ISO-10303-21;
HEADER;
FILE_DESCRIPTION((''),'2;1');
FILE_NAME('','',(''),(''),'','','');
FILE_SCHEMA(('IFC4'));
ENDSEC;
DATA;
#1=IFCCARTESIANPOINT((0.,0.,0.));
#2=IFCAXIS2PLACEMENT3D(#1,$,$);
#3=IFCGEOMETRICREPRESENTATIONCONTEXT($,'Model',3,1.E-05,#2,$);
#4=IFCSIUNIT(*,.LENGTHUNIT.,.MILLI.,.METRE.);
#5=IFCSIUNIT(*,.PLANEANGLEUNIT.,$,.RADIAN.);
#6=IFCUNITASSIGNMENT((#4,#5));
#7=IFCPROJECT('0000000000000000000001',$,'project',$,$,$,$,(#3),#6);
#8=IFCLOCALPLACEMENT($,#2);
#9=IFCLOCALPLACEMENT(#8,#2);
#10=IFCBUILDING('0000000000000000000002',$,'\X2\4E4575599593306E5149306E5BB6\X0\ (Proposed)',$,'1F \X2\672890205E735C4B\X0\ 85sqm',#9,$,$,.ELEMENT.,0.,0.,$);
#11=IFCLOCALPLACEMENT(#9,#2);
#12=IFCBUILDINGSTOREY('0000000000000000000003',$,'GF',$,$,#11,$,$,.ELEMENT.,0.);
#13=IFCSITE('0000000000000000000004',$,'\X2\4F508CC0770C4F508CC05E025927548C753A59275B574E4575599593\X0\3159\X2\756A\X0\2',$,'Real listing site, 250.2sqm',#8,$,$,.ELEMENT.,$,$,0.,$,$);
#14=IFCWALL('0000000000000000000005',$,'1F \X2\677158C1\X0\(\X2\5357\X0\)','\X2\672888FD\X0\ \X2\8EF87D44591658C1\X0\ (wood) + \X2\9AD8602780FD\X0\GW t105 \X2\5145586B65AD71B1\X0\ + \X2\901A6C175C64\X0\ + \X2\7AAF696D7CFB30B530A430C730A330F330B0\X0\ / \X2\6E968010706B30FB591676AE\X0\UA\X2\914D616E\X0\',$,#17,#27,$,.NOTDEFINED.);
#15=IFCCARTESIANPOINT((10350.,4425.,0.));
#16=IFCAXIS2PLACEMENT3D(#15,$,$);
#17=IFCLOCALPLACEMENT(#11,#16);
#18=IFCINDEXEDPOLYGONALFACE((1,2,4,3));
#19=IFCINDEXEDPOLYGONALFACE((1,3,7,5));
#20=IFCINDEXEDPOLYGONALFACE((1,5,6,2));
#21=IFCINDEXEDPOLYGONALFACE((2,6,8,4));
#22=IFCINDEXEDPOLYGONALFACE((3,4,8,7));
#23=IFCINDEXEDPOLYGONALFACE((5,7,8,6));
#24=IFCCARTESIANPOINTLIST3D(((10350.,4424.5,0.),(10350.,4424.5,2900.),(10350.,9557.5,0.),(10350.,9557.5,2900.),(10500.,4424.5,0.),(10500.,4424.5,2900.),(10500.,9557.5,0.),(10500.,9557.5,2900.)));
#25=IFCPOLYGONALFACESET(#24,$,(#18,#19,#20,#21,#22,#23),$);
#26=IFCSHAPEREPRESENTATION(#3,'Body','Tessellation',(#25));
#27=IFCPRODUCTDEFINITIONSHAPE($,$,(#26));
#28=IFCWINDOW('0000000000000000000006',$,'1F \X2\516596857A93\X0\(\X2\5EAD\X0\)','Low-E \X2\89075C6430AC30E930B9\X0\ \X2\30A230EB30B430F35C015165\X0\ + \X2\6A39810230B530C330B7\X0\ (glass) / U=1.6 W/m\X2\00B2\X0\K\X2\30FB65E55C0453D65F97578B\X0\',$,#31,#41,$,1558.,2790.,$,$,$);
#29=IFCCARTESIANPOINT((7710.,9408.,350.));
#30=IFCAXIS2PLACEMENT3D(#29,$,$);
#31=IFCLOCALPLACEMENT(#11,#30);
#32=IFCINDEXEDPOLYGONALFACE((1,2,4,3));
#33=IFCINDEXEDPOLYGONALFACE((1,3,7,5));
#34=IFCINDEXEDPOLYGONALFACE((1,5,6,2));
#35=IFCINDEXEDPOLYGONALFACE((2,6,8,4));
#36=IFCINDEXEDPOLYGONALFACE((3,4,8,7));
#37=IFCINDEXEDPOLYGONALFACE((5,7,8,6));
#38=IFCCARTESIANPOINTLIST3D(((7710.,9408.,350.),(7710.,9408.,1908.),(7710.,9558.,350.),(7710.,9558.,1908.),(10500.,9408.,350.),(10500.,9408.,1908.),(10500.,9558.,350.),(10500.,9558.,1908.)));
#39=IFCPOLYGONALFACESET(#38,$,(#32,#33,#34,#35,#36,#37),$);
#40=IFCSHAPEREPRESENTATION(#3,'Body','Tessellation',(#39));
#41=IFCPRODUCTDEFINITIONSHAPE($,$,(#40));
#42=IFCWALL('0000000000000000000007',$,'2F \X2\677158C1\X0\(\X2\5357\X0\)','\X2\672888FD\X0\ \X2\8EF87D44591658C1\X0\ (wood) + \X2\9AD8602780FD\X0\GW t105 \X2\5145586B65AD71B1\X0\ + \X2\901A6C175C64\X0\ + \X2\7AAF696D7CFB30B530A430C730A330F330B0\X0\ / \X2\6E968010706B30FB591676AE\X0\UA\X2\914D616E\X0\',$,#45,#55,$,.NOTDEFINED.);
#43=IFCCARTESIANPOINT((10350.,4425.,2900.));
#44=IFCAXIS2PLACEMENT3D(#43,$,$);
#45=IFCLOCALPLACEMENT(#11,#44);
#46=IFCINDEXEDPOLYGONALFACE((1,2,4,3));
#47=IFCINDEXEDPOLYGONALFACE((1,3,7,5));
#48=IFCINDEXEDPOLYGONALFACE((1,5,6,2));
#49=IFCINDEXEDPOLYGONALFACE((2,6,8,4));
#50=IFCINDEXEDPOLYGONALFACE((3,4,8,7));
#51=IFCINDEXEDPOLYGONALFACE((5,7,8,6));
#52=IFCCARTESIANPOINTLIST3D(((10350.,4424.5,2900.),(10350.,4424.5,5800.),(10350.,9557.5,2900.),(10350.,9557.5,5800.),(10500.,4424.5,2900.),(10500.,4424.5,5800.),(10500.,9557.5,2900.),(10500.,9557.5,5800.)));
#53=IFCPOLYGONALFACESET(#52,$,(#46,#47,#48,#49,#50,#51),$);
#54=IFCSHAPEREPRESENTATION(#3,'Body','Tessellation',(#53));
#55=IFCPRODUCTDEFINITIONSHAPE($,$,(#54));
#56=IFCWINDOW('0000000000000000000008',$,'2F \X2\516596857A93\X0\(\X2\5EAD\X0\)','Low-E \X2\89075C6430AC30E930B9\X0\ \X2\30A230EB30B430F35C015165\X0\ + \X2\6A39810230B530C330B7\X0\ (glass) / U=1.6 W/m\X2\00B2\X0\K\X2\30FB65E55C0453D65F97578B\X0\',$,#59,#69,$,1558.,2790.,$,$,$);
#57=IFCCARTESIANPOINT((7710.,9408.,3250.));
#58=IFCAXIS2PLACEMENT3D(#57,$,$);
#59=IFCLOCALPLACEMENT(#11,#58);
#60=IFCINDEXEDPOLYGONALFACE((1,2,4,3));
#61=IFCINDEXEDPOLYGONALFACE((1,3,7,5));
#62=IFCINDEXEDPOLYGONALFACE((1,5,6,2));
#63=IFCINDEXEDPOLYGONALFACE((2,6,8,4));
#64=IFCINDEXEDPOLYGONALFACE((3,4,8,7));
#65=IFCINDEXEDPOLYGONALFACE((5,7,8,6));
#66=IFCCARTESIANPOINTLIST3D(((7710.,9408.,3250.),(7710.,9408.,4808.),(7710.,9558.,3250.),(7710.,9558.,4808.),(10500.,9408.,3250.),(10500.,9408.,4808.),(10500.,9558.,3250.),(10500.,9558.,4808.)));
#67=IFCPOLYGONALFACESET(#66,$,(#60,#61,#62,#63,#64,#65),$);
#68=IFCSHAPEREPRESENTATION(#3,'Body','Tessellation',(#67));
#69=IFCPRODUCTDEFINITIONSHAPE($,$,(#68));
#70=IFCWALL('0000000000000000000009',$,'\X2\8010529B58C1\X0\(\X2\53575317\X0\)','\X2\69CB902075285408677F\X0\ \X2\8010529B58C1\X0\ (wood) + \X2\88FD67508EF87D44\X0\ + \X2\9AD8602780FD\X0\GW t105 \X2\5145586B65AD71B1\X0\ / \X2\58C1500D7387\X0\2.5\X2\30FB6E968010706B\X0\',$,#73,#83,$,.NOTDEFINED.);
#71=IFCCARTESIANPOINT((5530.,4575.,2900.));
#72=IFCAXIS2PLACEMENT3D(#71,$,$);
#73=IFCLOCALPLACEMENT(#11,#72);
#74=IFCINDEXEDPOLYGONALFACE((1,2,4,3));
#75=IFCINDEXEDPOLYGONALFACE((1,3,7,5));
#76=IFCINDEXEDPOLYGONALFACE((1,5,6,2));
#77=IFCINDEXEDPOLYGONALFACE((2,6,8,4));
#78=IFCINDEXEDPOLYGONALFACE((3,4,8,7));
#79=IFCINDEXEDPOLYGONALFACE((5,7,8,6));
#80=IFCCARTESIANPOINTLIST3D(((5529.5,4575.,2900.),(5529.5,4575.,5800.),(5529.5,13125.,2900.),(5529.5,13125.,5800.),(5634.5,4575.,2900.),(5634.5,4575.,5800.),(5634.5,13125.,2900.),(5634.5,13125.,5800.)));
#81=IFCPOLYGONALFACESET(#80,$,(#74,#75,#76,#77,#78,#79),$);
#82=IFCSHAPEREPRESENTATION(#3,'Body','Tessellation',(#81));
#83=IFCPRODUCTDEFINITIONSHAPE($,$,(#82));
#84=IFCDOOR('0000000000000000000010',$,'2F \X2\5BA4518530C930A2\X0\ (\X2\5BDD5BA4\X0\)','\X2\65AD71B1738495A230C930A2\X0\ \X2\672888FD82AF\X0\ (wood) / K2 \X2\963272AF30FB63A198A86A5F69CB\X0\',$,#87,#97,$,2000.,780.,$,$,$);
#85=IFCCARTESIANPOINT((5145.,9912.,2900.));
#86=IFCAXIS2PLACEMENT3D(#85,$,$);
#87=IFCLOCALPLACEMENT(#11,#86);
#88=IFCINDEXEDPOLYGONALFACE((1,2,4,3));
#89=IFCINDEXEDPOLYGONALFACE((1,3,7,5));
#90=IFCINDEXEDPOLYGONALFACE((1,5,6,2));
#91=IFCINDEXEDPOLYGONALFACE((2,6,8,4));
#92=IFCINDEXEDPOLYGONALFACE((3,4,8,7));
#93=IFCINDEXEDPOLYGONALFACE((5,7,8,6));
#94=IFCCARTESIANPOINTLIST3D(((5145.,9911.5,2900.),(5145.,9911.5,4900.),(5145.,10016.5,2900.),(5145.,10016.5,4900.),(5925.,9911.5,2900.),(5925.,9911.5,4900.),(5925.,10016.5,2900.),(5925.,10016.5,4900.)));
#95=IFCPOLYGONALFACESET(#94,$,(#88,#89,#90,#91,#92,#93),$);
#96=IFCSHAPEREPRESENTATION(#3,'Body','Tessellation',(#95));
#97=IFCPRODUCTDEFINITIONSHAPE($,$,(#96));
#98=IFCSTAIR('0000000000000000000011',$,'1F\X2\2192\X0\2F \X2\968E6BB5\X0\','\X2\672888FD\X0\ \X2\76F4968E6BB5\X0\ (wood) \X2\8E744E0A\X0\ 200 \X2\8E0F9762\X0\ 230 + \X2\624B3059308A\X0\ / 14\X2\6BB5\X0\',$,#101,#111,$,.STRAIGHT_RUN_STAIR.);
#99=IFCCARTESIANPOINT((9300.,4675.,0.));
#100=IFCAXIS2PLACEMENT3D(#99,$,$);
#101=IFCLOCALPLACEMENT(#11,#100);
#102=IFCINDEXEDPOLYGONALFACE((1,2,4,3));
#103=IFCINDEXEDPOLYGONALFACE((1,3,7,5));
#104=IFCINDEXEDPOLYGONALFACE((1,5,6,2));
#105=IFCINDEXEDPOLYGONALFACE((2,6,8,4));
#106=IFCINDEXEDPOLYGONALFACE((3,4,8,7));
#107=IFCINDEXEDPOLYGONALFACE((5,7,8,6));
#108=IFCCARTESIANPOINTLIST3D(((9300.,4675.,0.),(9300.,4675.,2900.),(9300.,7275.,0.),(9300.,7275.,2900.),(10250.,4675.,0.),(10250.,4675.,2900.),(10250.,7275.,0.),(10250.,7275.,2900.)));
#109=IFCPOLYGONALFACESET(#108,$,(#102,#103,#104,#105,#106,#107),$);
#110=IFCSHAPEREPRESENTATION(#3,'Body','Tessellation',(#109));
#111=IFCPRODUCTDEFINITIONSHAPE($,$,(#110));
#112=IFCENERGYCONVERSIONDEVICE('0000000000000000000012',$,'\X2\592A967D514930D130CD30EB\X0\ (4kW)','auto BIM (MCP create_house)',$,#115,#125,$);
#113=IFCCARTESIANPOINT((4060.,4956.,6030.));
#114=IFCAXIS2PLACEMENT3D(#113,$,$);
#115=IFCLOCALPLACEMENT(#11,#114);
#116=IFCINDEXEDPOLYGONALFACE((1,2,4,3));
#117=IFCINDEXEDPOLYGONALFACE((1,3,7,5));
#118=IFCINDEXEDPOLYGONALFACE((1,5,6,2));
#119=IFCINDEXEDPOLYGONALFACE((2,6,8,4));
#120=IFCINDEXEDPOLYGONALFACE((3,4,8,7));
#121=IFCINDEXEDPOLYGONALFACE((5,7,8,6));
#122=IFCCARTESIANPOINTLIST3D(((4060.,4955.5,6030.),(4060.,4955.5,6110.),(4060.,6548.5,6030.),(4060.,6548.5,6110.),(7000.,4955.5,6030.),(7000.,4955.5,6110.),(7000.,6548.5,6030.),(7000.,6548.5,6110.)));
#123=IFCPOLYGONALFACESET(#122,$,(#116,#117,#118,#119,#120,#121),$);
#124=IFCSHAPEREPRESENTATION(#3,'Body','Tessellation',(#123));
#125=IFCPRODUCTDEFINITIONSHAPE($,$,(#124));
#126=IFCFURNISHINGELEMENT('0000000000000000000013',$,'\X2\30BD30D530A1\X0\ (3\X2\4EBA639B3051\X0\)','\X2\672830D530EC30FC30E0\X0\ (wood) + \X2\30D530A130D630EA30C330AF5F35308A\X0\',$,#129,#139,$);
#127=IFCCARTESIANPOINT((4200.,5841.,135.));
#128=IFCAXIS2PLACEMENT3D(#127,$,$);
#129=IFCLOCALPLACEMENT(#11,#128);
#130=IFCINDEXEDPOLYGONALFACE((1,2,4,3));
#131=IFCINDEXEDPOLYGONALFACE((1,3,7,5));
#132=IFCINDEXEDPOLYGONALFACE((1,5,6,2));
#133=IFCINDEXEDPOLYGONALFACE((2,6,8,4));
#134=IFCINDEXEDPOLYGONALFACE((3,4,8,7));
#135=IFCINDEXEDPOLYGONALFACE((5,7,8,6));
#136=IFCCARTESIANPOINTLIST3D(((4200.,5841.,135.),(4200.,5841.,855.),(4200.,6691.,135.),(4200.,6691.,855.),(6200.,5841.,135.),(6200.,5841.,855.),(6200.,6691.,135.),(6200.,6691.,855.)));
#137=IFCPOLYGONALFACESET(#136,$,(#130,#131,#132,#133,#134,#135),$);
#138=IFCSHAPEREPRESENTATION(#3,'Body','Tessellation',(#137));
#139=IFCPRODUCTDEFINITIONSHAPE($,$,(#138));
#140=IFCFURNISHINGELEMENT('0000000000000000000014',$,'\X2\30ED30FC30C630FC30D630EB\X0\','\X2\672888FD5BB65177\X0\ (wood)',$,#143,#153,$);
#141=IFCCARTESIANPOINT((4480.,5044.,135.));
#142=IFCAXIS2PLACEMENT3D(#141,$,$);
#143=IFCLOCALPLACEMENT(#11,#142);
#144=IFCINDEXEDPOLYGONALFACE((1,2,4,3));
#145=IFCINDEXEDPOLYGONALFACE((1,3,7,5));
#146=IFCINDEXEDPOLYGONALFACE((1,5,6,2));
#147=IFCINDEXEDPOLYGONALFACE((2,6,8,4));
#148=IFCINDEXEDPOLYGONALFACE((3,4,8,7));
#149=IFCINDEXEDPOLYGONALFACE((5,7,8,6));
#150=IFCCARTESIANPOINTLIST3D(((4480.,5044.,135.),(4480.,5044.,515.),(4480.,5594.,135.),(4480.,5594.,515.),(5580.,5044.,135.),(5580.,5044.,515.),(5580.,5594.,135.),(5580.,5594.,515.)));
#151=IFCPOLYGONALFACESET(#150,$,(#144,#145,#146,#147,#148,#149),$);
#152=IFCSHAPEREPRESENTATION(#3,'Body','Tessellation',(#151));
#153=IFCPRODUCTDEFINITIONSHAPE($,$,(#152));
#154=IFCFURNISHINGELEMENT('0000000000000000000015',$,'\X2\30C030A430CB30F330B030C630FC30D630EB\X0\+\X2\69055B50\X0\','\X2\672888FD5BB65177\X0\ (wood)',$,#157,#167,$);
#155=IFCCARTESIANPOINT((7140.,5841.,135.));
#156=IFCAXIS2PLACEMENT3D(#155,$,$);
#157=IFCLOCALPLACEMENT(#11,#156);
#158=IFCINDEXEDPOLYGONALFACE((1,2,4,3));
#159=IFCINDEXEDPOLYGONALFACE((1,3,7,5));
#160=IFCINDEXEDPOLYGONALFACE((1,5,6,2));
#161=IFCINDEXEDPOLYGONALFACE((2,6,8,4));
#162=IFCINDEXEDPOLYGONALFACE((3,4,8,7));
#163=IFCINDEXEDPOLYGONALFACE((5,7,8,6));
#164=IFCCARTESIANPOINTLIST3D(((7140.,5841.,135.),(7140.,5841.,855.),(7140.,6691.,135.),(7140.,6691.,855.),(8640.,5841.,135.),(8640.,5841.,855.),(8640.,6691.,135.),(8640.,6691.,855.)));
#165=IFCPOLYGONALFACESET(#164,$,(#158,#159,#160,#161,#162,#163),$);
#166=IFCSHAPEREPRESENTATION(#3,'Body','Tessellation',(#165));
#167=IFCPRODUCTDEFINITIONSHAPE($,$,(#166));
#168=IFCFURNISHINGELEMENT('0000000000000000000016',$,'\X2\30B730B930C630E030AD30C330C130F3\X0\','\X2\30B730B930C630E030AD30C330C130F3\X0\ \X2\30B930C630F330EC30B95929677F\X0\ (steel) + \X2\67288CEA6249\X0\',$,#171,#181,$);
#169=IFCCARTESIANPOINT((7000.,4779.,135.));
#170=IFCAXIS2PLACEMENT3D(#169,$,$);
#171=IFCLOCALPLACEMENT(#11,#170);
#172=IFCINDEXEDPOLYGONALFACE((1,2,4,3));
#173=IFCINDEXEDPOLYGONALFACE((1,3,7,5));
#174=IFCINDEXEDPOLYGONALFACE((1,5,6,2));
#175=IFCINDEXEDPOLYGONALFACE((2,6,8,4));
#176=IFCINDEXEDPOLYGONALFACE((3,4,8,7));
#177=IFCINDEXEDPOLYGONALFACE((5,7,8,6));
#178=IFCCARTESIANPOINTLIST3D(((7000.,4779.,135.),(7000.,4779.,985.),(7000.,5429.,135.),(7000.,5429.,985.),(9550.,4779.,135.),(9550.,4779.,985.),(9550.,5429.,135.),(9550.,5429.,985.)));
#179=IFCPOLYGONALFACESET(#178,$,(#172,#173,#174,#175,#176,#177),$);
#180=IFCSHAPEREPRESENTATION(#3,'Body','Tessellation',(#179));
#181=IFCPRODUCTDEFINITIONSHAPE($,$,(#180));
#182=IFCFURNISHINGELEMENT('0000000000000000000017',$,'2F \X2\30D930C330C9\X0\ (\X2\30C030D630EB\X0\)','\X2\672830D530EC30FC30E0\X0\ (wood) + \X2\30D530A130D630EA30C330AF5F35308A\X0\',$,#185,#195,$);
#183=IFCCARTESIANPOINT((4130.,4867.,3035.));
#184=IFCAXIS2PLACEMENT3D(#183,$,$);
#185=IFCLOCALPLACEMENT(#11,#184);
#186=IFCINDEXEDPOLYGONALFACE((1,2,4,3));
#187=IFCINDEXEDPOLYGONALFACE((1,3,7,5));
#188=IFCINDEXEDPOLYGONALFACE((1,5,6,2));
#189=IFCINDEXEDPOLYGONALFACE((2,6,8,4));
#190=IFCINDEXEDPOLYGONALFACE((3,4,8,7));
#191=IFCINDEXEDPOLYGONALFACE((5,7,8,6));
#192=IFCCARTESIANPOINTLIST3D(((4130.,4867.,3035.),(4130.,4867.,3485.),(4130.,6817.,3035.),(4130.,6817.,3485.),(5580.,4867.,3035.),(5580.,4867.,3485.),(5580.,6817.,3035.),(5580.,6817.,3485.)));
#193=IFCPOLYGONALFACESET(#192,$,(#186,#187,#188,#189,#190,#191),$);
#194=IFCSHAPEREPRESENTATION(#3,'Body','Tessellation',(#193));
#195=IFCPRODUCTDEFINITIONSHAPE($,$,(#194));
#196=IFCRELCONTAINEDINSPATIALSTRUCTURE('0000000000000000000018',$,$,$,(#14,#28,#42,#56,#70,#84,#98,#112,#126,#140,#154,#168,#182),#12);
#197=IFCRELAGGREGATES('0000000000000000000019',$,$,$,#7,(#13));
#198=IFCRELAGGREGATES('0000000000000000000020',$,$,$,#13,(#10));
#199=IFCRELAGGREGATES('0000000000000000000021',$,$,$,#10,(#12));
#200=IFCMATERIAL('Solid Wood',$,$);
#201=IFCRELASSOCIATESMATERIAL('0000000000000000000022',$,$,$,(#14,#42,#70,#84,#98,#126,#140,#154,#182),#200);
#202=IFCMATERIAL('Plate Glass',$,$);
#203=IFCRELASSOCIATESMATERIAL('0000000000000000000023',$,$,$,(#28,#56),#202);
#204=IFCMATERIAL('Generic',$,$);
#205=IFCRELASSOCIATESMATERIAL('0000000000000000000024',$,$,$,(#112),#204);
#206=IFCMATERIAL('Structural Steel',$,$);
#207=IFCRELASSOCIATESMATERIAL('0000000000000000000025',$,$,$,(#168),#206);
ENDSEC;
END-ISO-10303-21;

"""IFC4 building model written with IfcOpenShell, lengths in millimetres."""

from ifc_helpers import new_model, si_unit, frame, frame_2d, origin, place, context, project, spatial, rectangle, extrude, material, element, fill, save


model = new_model("IFC4")

# Units and contexts
model_context = context("Model", 3, precision=1e-05, world=origin())
ifc_project = project(units=[si_unit("LENGTHUNIT", "METRE", prefix="MILLI"), si_unit("PLANEANGLEUNIT", "RADIAN")], contexts=[model_context])

# Site, building, storey
site_placement = place(None, origin())
site = spatial("IfcSite", under=ifc_project, at=site_placement, Name="佐賀県佐賀市大和町大字久留間3159番2", ObjectType="Real listing site, 250.2sqm", CompositionType="ELEMENT", RefElevation=0.0)
building_placement = place(site_placement, origin())
building = spatial("IfcBuilding", under=site, at=building_placement, Name="久留間の光の家 (Proposed)", ObjectType="1F 木造平屋 85sqm", CompositionType="ELEMENT", ElevationOfRefHeight=0.0, ElevationOfTerrain=0.0)
storey_placement = place(building_placement, origin())
storey = spatial("IfcBuildingStorey", under=building, at=storey_placement, Name="GF", CompositionType="ELEMENT", Elevation=0.0)

# Wall, opening, window
ifc_material_1 = material(Name="Solid Wood")
wall_1_placement = place(storey_placement, frame((10350.0, 4425.0, 0.0)))
wall_1 = element("IfcWall", 1, at=wall_1_placement, inside=storey, material=ifc_material_1, Name="1F 東壁(南)", Description="木製 軸組外壁 (wood) + 高性能GW t105 充填断熱 + 通気層 + 窯業系サイディング / 準耐火・外皮UA配慮", PredefinedType="NOTDEFINED", context=model_context, shape_type="SweptSolid", body=[
    extrude(rectangle(XDim=150.0, YDim=5133.0, at=frame_2d((75.0, 2566.0))), frame((10350.0, 4425.0, 0.0)), (0.0, 0.0, 1.0), 2900.0),
])
opening_1_placement = place(storey_placement, frame((7710.0, 9408.0, 350.0)))
opening_1 = element("IfcOpeningElement", 2, at=opening_1_placement, cuts=wall_1, PredefinedType="NOTDEFINED", context=model_context, shape_type="SweptSolid", body=[
    extrude(rectangle(XDim=2790.0, YDim=150.0, at=frame_2d((1395.0, 75.0))), frame((7710.0, 9408.0, 350.0)), (0.0, 0.0, 1.0), 1558.0),
])
ifc_material_2 = material(Name="Plate Glass")
window_1_placement = place(storey_placement, frame((7710.0, 9408.0, 350.0)))
window_1 = element("IfcWindow", 3, at=window_1_placement, inside=storey, material=ifc_material_2, Name="1F 入隅窓(庭)", Description="Low-E 複層ガラス アルゴン封入 + 樹脂サッシ (glass) / U=1.6 W/m²K・日射取得型", OverallHeight=1558.0, OverallWidth=2790.0, context=model_context, shape_type="SweptSolid", body=[
    extrude(rectangle(XDim=2790.0, YDim=150.0, at=frame_2d((1395.0, 75.0))), frame((7710.0, 9408.0, 350.0)), (0.0, 0.0, 1.0), 1558.0),
])
fill(opening_1, window_1)

# Wall, opening, window
wall_2_placement = place(storey_placement, frame((10350.0, 4425.0, 2900.0)))
wall_2 = element("IfcWall", 4, at=wall_2_placement, inside=storey, material=ifc_material_1, Name="2F 東壁(南)", Description="木製 軸組外壁 (wood) + 高性能GW t105 充填断熱 + 通気層 + 窯業系サイディング / 準耐火・外皮UA配慮", PredefinedType="NOTDEFINED", context=model_context, shape_type="SweptSolid", body=[
    extrude(rectangle(XDim=150.0, YDim=5133.0, at=frame_2d((75.0, 2566.0))), frame((10350.0, 4425.0, 2900.0)), (0.0, 0.0, 1.0), 2900.0),
])
opening_2_placement = place(storey_placement, frame((7710.0, 9408.0, 3250.0)))
opening_2 = element("IfcOpeningElement", 5, at=opening_2_placement, cuts=wall_2, PredefinedType="NOTDEFINED", context=model_context, shape_type="SweptSolid", body=[
    extrude(rectangle(XDim=2790.0, YDim=150.0, at=frame_2d((1395.0, 75.0))), frame((7710.0, 9408.0, 3250.0)), (0.0, 0.0, 1.0), 1558.0),
])
window_2_placement = place(storey_placement, frame((7710.0, 9408.0, 3250.0)))
window_2 = element("IfcWindow", 6, at=window_2_placement, inside=storey, material=ifc_material_2, Name="2F 入隅窓(庭)", Description="Low-E 複層ガラス アルゴン封入 + 樹脂サッシ (glass) / U=1.6 W/m²K・日射取得型", OverallHeight=1558.0, OverallWidth=2790.0, context=model_context, shape_type="SweptSolid", body=[
    extrude(rectangle(XDim=2790.0, YDim=150.0, at=frame_2d((1395.0, 75.0))), frame((7710.0, 9408.0, 3250.0)), (0.0, 0.0, 1.0), 1558.0),
])
fill(opening_2, window_2)

# Wall, opening, door
wall_3_placement = place(storey_placement, frame((5530.0, 4575.0, 2900.0)))
wall_3 = element("IfcWall", 7, at=wall_3_placement, inside=storey, material=ifc_material_1, Name="耐力壁(南北)", Description="構造用合板 耐力壁 (wood) + 製材軸組 + 高性能GW t105 充填断熱 / 壁倍率2.5・準耐火", PredefinedType="NOTDEFINED", context=model_context, shape_type="SweptSolid", body=[
    extrude(rectangle(XDim=105.0, YDim=8550.0, at=frame_2d((52.0, 4275.0))), frame((5530.0, 4575.0, 2900.0)), (0.0, 0.0, 1.0), 2900.0),
])
opening_3_placement = place(storey_placement, frame((5145.0, 9912.0, 2900.0)))
opening_3 = element("IfcOpeningElement", 8, at=opening_3_placement, cuts=wall_3, PredefinedType="NOTDEFINED", context=model_context, shape_type="SweptSolid", body=[
    extrude(rectangle(XDim=780.0, YDim=105.0, at=frame_2d((390.0, 52.0))), frame((5145.0, 9912.0, 2900.0)), (0.0, 0.0, 1.0), 2000.0),
])
door_1_placement = place(storey_placement, frame((5145.0, 9912.0, 2900.0)))
door_1 = element("IfcDoor", 9, at=door_1_placement, inside=storey, material=ifc_material_1, Name="2F 室内ドア (寝室)", Description="断熱玄関ドア 木製芯 (wood) / K2 防犯・採風機構", OverallHeight=2000.0, OverallWidth=780.0, context=model_context, shape_type="SweptSolid", body=[
    extrude(rectangle(XDim=780.0, YDim=105.0, at=frame_2d((390.0, 52.0))), frame((5145.0, 9912.0, 2900.0)), (0.0, 0.0, 1.0), 2000.0),
])
fill(opening_3, door_1)

# Stair
stair_placement = place(storey_placement, frame((9300.0, 4675.0, 0.0)))
element("IfcStair", 10, at=stair_placement, inside=storey, material=ifc_material_1, Name="1F→2F 階段", Description="木製 直階段 (wood) 蹴上 200 踏面 230 + 手すり / 14段", PredefinedType="STRAIGHT_RUN_STAIR", context=model_context, shape_type="SweptSolid", body=[
    extrude(rectangle(XDim=950.0, YDim=2600.0, at=frame_2d((475.0, 1300.0))), frame((9300.0, 4675.0, 0.0)), (0.0, 0.0, 1.0), 2900.0),
])

# Energy conversion device
ifc_material_3 = material(Name="Generic")
energy_conversion_device_placement = place(storey_placement, frame((4060.0, 4956.0, 6030.0)))
element("IfcEnergyConversionDevice", 11, at=energy_conversion_device_placement, inside=storey, material=ifc_material_3, Name="太陽光パネル (4kW)", Description="auto BIM (MCP create_house)", context=model_context, shape_type="SweptSolid", body=[
    extrude(rectangle(XDim=2940.0, YDim=1593.0, at=frame_2d((1470.0, 796.0))), frame((4060.0, 4956.0, 6030.0)), (0.0, 0.0, 1.0), 80.0),
])

# Furnishing elements
furnishing_1_placement = place(storey_placement, frame((4200.0, 5841.0, 135.0)))
element("IfcFurnishingElement", 12, at=furnishing_1_placement, inside=storey, material=ifc_material_1, Name="ソファ (3人掛け)", Description="木フレーム (wood) + ファブリック張り", context=model_context, shape_type="SweptSolid", body=[
    extrude(rectangle(XDim=2000.0, YDim=850.0, at=frame_2d((1000.0, 425.0))), frame((4200.0, 5841.0, 135.0)), (0.0, 0.0, 1.0), 720.0),
])
furnishing_2_placement = place(storey_placement, frame((4480.0, 5044.0, 135.0)))
element("IfcFurnishingElement", 13, at=furnishing_2_placement, inside=storey, material=ifc_material_1, Name="ローテーブル", Description="木製家具 (wood)", context=model_context, shape_type="SweptSolid", body=[
    extrude(rectangle(XDim=1100.0, YDim=550.0, at=frame_2d((550.0, 275.0))), frame((4480.0, 5044.0, 135.0)), (0.0, 0.0, 1.0), 380.0),
])
furnishing_3_placement = place(storey_placement, frame((7140.0, 5841.0, 135.0)))
element("IfcFurnishingElement", 14, at=furnishing_3_placement, inside=storey, material=ifc_material_1, Name="ダイニングテーブル+椅子", Description="木製家具 (wood)", context=model_context, shape_type="SweptSolid", body=[
    extrude(rectangle(XDim=1500.0, YDim=850.0, at=frame_2d((750.0, 425.0))), frame((7140.0, 5841.0, 135.0)), (0.0, 0.0, 1.0), 720.0),
])
ifc_material_4 = material(Name="Structural Steel")
furnishing_4_placement = place(storey_placement, frame((7000.0, 4779.0, 135.0)))
element("IfcFurnishingElement", 15, at=furnishing_4_placement, inside=storey, material=ifc_material_4, Name="システムキッチン", Description="システムキッチン ステンレス天板 (steel) + 木質扉", context=model_context, shape_type="SweptSolid", body=[
    extrude(rectangle(XDim=2550.0, YDim=650.0, at=frame_2d((1275.0, 325.0))), frame((7000.0, 4779.0, 135.0)), (0.0, 0.0, 1.0), 850.0),
])
furnishing_5_placement = place(storey_placement, frame((4130.0, 4867.0, 3035.0)))
element("IfcFurnishingElement", 16, at=furnishing_5_placement, inside=storey, material=ifc_material_1, Name="2F ベッド (ダブル)", Description="木フレーム (wood) + ファブリック張り", context=model_context, shape_type="SweptSolid", body=[
    extrude(rectangle(XDim=1450.0, YDim=1950.0, at=frame_2d((725.0, 975.0))), frame((4130.0, 4867.0, 3035.0)), (0.0, 0.0, 1.0), 450.0),
])

save(model, "model.ifc")
